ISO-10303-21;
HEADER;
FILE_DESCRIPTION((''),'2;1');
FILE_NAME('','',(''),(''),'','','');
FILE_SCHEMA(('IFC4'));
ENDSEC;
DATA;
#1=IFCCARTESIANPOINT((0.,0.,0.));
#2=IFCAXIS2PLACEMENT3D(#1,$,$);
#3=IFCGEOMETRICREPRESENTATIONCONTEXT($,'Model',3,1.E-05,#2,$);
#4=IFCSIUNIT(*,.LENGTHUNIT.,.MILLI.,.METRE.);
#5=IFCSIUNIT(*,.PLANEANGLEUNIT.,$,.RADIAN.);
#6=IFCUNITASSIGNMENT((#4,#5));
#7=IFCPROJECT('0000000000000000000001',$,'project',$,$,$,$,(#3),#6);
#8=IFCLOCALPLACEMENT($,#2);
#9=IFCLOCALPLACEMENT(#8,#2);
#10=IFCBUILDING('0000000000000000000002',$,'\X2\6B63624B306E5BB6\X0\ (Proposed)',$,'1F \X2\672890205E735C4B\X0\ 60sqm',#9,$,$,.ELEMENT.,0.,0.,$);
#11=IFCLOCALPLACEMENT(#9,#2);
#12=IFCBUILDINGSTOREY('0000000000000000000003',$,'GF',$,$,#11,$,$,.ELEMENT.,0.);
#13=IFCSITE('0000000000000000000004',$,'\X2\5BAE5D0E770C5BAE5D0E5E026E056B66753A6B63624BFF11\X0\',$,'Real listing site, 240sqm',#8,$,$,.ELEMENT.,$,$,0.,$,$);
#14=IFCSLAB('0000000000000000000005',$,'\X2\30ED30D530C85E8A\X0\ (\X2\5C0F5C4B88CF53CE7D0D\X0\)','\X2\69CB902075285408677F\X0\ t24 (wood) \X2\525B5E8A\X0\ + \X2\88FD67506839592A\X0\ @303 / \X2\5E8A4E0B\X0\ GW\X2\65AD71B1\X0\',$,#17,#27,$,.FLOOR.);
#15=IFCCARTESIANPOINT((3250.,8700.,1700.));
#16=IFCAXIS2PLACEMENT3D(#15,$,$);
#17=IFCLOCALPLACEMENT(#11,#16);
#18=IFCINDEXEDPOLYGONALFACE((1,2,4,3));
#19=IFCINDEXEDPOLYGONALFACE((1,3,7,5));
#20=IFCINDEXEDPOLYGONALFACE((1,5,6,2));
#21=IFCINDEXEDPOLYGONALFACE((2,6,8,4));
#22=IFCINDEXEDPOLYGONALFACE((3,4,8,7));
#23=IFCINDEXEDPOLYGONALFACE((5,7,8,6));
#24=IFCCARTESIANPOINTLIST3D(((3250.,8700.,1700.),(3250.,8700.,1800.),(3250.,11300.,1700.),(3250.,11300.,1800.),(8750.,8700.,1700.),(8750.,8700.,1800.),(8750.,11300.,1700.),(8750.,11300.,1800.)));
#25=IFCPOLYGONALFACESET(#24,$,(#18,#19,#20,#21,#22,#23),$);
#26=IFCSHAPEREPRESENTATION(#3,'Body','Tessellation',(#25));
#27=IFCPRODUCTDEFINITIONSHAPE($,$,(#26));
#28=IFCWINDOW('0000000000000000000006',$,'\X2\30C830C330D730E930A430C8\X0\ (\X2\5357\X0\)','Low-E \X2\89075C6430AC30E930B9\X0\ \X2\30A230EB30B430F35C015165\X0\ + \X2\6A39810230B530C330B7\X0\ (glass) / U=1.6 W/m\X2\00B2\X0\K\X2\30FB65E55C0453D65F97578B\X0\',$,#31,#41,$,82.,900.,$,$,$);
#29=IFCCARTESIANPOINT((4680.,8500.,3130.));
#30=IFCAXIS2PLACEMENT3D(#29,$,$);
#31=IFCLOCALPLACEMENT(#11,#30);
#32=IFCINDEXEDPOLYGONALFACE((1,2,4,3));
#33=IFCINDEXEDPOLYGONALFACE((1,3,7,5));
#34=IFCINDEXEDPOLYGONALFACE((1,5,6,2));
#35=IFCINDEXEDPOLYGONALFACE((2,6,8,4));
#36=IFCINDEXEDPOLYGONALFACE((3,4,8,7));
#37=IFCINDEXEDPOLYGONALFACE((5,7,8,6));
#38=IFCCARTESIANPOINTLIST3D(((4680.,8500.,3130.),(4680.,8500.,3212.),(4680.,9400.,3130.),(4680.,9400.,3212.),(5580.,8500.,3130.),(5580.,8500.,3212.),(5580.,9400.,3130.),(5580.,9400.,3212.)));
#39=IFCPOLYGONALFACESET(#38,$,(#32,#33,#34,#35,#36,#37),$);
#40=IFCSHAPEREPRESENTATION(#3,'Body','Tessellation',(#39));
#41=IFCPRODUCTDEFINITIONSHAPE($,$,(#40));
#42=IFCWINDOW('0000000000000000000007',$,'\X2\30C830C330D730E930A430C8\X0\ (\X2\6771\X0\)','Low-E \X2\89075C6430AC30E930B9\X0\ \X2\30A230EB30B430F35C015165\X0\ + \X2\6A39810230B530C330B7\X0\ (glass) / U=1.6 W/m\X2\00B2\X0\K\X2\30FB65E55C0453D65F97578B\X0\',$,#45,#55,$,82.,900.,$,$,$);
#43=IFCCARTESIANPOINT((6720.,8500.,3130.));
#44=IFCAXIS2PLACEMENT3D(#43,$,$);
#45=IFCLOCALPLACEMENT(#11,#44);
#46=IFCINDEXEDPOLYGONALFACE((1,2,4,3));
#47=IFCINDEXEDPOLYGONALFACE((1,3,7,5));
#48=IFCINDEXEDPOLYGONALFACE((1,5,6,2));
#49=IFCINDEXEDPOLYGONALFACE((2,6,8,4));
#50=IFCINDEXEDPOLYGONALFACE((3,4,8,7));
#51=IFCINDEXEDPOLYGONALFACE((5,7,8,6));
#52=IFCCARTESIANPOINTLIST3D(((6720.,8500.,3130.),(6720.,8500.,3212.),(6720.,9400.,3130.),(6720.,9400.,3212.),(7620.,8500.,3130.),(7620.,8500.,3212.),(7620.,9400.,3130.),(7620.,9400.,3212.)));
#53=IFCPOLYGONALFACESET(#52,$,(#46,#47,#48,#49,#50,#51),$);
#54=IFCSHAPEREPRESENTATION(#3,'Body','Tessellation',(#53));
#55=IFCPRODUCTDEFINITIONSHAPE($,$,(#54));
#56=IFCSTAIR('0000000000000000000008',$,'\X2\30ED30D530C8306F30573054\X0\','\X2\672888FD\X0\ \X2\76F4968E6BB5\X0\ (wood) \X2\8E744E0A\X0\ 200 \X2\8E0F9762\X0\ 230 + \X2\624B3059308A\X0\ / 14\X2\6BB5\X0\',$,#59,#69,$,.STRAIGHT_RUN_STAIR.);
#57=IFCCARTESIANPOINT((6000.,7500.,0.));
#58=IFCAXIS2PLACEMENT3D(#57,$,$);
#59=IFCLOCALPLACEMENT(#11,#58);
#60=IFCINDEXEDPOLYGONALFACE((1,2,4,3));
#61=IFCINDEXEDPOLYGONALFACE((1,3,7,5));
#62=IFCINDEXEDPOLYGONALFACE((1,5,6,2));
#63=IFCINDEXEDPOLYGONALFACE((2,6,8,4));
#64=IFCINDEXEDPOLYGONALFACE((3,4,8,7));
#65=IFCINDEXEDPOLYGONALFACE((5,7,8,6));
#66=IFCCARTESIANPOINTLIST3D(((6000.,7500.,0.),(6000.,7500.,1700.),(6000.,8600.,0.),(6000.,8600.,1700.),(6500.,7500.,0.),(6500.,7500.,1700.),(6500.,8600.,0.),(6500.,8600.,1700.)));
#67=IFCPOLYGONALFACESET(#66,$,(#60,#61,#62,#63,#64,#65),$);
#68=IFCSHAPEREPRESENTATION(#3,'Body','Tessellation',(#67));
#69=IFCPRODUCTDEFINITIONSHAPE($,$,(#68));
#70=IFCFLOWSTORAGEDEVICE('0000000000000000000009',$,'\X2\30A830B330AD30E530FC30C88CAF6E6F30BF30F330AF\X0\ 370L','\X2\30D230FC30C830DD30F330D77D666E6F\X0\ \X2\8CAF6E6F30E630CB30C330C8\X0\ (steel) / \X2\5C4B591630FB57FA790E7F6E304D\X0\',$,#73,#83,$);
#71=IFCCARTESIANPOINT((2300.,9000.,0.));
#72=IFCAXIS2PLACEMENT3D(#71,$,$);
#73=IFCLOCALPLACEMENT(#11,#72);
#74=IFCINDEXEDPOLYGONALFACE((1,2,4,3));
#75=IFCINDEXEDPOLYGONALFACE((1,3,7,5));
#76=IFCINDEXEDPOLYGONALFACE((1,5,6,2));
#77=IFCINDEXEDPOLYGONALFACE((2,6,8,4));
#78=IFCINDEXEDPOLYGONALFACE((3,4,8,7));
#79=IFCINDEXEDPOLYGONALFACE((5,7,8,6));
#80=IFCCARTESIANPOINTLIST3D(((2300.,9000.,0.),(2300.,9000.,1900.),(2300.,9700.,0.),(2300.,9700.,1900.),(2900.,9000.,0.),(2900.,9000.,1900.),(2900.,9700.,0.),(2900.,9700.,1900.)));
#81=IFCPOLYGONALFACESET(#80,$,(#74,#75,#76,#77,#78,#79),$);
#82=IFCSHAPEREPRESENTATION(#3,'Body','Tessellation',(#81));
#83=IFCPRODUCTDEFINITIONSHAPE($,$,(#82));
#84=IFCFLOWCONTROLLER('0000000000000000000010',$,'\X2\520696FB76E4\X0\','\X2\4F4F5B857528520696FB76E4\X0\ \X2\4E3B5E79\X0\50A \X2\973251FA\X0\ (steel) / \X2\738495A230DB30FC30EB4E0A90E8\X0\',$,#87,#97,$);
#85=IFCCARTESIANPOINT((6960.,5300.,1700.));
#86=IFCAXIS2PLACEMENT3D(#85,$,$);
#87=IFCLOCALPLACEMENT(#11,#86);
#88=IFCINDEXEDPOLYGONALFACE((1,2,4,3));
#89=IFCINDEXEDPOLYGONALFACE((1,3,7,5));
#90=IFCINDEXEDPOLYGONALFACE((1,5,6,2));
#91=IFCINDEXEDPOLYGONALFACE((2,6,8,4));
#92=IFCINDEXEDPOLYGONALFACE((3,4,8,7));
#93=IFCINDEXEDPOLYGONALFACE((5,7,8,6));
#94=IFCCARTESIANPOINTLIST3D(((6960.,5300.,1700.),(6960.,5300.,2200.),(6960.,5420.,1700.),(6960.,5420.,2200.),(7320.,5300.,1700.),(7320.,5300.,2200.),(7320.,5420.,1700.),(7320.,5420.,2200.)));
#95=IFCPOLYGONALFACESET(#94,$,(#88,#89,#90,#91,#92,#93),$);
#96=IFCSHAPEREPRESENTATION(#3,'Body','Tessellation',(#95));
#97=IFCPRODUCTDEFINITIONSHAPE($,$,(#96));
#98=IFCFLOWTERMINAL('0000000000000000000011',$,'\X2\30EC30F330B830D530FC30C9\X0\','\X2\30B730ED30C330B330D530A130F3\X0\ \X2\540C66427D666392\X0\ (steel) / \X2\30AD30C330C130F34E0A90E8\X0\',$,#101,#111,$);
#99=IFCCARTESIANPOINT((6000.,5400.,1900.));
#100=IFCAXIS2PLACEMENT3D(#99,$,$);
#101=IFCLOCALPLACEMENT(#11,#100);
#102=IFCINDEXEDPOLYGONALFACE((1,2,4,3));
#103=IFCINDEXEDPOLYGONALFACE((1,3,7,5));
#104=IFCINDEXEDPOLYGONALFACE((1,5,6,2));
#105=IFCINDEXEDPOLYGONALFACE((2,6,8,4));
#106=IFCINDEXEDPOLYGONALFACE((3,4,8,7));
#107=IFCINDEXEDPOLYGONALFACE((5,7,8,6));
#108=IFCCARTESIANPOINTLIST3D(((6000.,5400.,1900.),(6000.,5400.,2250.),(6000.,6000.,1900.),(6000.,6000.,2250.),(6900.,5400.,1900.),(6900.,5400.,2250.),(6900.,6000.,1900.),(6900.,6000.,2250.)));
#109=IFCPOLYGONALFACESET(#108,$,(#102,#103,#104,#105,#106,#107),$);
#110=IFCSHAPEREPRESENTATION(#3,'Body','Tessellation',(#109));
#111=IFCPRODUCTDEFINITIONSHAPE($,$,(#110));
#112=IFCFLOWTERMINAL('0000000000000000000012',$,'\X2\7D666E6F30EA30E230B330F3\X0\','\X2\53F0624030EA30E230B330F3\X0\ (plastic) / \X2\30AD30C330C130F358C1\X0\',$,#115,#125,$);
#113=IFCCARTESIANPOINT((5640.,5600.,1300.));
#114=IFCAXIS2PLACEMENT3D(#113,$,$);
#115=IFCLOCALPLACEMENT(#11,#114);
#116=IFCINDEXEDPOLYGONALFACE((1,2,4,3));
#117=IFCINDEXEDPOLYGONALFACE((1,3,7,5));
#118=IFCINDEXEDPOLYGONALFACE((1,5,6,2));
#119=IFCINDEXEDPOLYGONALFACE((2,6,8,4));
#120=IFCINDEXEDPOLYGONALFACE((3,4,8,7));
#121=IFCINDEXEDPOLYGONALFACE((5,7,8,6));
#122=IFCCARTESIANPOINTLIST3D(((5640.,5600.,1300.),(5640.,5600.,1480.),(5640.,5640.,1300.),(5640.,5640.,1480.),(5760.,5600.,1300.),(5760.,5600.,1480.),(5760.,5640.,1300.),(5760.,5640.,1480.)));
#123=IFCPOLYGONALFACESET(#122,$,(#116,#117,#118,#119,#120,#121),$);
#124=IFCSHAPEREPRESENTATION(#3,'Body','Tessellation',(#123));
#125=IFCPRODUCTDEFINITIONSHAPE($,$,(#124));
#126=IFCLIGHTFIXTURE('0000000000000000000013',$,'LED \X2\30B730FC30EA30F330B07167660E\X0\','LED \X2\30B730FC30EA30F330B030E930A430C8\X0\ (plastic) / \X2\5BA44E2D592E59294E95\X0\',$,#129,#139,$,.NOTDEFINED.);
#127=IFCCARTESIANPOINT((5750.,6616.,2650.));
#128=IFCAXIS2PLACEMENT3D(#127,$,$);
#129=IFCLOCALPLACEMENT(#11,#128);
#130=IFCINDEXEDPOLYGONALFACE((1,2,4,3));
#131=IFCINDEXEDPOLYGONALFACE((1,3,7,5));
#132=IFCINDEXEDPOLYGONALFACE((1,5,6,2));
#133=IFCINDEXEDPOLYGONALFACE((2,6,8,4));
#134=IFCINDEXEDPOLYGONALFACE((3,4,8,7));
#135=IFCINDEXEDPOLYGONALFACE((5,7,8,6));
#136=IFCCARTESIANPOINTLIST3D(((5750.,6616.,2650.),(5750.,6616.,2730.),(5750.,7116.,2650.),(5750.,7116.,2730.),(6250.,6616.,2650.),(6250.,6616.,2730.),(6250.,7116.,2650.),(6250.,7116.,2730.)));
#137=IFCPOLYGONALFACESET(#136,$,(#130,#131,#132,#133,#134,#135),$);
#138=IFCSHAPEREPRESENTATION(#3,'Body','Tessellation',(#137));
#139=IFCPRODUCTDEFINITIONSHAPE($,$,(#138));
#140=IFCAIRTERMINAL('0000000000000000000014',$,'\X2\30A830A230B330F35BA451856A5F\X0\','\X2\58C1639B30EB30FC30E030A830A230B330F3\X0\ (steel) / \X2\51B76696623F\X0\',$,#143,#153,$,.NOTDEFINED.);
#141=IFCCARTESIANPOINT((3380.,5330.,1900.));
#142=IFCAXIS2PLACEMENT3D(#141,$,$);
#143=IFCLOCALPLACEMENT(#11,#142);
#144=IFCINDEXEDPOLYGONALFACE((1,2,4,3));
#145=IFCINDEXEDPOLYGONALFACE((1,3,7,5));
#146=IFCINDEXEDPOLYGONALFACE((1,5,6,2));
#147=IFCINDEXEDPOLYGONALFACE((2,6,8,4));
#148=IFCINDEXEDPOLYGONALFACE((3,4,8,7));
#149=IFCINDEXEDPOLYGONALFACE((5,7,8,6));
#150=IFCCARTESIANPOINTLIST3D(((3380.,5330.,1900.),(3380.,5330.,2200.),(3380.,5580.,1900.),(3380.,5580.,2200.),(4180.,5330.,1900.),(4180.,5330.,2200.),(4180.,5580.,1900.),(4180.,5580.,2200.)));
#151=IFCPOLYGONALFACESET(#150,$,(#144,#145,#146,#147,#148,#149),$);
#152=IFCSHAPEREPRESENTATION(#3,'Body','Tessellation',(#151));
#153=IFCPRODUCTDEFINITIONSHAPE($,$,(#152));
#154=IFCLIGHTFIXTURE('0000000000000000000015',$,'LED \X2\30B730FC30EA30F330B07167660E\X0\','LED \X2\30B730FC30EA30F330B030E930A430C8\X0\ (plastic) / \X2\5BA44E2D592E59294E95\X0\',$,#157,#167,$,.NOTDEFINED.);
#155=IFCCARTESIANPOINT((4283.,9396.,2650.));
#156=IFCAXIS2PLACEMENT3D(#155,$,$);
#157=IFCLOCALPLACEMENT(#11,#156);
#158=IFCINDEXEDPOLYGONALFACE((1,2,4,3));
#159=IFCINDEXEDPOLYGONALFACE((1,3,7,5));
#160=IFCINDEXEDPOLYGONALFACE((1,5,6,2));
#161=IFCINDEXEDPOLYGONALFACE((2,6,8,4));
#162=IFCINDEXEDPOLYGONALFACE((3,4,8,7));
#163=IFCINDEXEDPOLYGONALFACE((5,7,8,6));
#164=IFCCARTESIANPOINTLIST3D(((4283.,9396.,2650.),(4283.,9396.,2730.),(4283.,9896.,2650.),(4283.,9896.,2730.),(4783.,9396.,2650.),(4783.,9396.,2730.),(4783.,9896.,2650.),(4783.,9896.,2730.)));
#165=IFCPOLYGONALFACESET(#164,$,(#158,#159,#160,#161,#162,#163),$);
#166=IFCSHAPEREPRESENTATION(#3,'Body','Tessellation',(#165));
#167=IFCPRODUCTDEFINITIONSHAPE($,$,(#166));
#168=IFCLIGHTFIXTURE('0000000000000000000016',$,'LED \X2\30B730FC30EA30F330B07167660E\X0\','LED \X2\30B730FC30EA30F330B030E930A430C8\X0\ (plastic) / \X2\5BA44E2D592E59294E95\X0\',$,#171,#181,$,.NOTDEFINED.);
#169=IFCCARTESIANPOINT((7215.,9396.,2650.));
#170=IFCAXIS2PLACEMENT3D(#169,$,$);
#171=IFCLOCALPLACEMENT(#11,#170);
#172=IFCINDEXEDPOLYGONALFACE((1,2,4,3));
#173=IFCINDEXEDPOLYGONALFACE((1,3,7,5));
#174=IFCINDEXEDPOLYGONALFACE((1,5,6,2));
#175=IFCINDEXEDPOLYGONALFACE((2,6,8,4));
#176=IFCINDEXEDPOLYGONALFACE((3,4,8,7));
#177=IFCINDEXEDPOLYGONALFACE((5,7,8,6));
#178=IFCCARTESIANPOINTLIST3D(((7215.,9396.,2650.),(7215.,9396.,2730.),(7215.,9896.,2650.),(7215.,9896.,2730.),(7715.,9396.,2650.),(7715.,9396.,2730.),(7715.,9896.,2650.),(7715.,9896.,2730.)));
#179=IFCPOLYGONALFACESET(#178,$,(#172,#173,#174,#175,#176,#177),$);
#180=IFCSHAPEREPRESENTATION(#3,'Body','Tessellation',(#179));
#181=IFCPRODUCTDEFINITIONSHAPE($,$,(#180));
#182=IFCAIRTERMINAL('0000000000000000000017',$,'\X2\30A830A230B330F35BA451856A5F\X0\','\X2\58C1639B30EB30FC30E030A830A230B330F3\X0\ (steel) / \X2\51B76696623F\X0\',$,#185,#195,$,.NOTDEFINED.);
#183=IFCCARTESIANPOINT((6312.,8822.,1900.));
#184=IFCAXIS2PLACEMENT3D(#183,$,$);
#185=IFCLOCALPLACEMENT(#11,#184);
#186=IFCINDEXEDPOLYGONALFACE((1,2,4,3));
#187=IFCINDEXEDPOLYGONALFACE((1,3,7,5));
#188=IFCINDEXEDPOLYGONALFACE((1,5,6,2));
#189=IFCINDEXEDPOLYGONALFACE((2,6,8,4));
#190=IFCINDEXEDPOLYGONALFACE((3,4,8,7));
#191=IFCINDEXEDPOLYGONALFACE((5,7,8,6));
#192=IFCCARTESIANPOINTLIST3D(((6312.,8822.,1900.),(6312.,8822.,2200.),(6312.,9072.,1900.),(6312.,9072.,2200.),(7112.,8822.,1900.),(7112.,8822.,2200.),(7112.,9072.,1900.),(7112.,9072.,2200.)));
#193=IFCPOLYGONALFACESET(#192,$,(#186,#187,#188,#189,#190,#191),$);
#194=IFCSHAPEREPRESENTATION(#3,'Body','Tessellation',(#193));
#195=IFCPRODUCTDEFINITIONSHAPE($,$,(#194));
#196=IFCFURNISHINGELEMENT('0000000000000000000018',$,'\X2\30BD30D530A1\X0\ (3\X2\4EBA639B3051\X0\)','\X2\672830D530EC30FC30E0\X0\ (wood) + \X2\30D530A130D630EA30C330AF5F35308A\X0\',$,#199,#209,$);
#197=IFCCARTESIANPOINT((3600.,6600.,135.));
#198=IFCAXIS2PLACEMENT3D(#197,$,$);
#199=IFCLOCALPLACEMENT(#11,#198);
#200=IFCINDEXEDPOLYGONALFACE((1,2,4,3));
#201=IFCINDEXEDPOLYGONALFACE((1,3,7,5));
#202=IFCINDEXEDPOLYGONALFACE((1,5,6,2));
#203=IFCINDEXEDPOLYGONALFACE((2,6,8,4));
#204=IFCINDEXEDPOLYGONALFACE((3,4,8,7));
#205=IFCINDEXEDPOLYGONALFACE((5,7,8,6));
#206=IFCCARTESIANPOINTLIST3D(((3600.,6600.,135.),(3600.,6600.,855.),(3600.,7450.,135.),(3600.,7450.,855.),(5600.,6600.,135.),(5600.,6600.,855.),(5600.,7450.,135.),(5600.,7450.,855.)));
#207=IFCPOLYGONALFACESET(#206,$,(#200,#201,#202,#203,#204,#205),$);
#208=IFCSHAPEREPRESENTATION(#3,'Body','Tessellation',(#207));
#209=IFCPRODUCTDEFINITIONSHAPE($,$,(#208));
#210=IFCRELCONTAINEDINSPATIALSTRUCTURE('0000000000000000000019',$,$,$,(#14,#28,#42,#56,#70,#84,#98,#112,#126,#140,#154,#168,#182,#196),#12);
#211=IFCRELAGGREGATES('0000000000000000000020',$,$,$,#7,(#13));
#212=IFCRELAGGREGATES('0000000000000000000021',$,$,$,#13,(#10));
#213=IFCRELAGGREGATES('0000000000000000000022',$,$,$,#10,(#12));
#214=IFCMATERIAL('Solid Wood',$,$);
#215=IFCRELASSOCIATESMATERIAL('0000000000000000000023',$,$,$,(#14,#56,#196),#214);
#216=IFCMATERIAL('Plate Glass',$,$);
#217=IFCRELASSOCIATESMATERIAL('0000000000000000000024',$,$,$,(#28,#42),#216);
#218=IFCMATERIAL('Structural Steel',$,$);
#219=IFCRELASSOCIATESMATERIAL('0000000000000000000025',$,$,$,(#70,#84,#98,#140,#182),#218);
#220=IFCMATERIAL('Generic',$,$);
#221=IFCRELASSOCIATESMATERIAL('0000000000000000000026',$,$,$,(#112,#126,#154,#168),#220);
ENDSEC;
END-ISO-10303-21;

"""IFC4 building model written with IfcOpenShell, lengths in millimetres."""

from ifc_helpers import new_model, si_unit, frame, frame_2d, origin, place, context, project, spatial, rectangle, extrude, material, element, save


model = new_model("IFC4")

# Units and contexts
model_context = context("Model", 3, precision=1e-05, world=origin())
ifc_project = project(units=[si_unit("LENGTHUNIT", "METRE", prefix="MILLI"), si_unit("PLANEANGLEUNIT", "RADIAN")], contexts=[model_context])

# Site, building, storey
site_placement = place(None, origin())
site = spatial("IfcSite", under=ifc_project, at=site_placement, Name="宮崎県宮崎市清武町正手１", ObjectType="Real listing site, 240sqm", CompositionType="ELEMENT", RefElevation=0.0)
building_placement = place(site_placement, origin())
building = spatial("IfcBuilding", under=site, at=building_placement, Name="正手の家 (Proposed)", ObjectType="1F 木造平屋 60sqm", CompositionType="ELEMENT", ElevationOfRefHeight=0.0, ElevationOfTerrain=0.0)
storey_placement = place(building_placement, origin())
storey = spatial("IfcBuildingStorey", under=building, at=storey_placement, Name="GF", CompositionType="ELEMENT", Elevation=0.0)

# Shared definitions
ifc_material_1 = material(Name="Solid Wood")

# Slab
slab_placement = place(storey_placement, frame((3250.0, 8700.0, 1700.0)))
element("IfcSlab", 1, at=slab_placement, inside=storey, material=ifc_material_1, Name="ロフト床 (小屋裏収納)", Description="構造用合板 t24 (wood) 剛床 + 製材根太 @303 / 床下 GW断熱", PredefinedType="FLOOR", context=model_context, shape_type="SweptSolid", body=[
    extrude(rectangle(XDim=5500.0, YDim=2600.0, at=frame_2d((2750.0, 1300.0))), frame((3250.0, 8700.0, 1700.0)), (0.0, 0.0, 1.0), 100.0),
])

# Windows
ifc_material_2 = material(Name="Plate Glass")
window_1_placement = place(storey_placement, frame((4680.0, 8500.0, 3130.0)))
element("IfcWindow", 2, at=window_1_placement, inside=storey, material=ifc_material_2, Name="トップライト (南)", Description="Low-E 複層ガラス アルゴン封入 + 樹脂サッシ (glass) / U=1.6 W/m²K・日射取得型", OverallHeight=82.0, OverallWidth=900.0, context=model_context, shape_type="SweptSolid", body=[
    extrude(rectangle(XDim=900.0, YDim=900.0, at=frame_2d((450.0, 450.0))), frame((4680.0, 8500.0, 3130.0)), (0.0, 0.0, 1.0), 82.0),
])
window_2_placement = place(storey_placement, frame((6720.0, 8500.0, 3130.0)))
element("IfcWindow", 3, at=window_2_placement, inside=storey, material=ifc_material_2, Name="トップライト (東)", Description="Low-E 複層ガラス アルゴン封入 + 樹脂サッシ (glass) / U=1.6 W/m²K・日射取得型", OverallHeight=82.0, OverallWidth=900.0, context=model_context, shape_type="SweptSolid", body=[
    extrude(rectangle(XDim=900.0, YDim=900.0, at=frame_2d((450.0, 450.0))), frame((6720.0, 8500.0, 3130.0)), (0.0, 0.0, 1.0), 82.0),
])

# Stair
stair_placement = place(storey_placement, frame((6000.0, 7500.0, 0.0)))
element("IfcStair", 4, at=stair_placement, inside=storey, material=ifc_material_1, Name="ロフトはしご", Description="木製 直階段 (wood) 蹴上 200 踏面 230 + 手すり / 14段", PredefinedType="STRAIGHT_RUN_STAIR", context=model_context, shape_type="SweptSolid", body=[
    extrude(rectangle(XDim=500.0, YDim=1100.0, at=frame_2d((250.0, 550.0))), frame((6000.0, 7500.0, 0.0)), (0.0, 0.0, 1.0), 1700.0),
])

# Flow storage device
ifc_material_3 = material(Name="Structural Steel")
flow_storage_device_placement = place(storey_placement, frame((2300.0, 9000.0, 0.0)))
element("IfcFlowStorageDevice", 5, at=flow_storage_device_placement, inside=storey, material=ifc_material_3, Name="エコキュート貯湯タンク 370L", Description="ヒートポンプ給湯 貯湯ユニット (steel) / 屋外・基礎置き", context=model_context, shape_type="SweptSolid", body=[
    extrude(rectangle(XDim=600.0, YDim=700.0, at=frame_2d((300.0, 350.0))), frame((2300.0, 9000.0, 0.0)), (0.0, 0.0, 1.0), 1900.0),
])

# Flow controller
flow_controller_placement = place(storey_placement, frame((6960.0, 5300.0, 1700.0)))
element("IfcFlowController", 6, at=flow_controller_placement, inside=storey, material=ifc_material_3, Name="分電盤", Description="住宅用分電盤 主幹50A 露出 (steel) / 玄関ホール上部", context=model_context, shape_type="SweptSolid", body=[
    extrude(rectangle(XDim=360.0, YDim=120.0, at=frame_2d((180.0, 60.0))), frame((6960.0, 5300.0, 1700.0)), (0.0, 0.0, 1.0), 500.0),
])

# Flow terminals
flow_terminal_1_placement = place(storey_placement, frame((6000.0, 5400.0, 1900.0)))
element("IfcFlowTerminal", 7, at=flow_terminal_1_placement, inside=storey, material=ifc_material_3, Name="レンジフード", Description="シロッコファン 同時給排 (steel) / キッチン上部", context=model_context, shape_type="SweptSolid", body=[
    extrude(rectangle(XDim=900.0, YDim=600.0, at=frame_2d((450.0, 300.0))), frame((6000.0, 5400.0, 1900.0)), (0.0, 0.0, 1.0), 350.0),
])
ifc_material_4 = material(Name="Generic")
flow_terminal_2_placement = place(storey_placement, frame((5640.0, 5600.0, 1300.0)))
element("IfcFlowTerminal", 8, at=flow_terminal_2_placement, inside=storey, material=ifc_material_4, Name="給湯リモコン", Description="台所リモコン (plastic) / キッチン壁", context=model_context, shape_type="SweptSolid", body=[
    extrude(rectangle(XDim=120.0, YDim=40.0, at=frame_2d((60.0, 20.0))), frame((5640.0, 5600.0, 1300.0)), (0.0, 0.0, 1.0), 180.0),
])

# Light fixture
light_fixture_1_placement = place(storey_placement, frame((5750.0, 6616.0, 2650.0)))
element("IfcLightFixture", 9, at=light_fixture_1_placement, inside=storey, material=ifc_material_4, Name="LED シーリング照明", Description="LED シーリングライト (plastic) / 室中央天井", PredefinedType="NOTDEFINED", context=model_context, shape_type="SweptSolid", body=[
    extrude(rectangle(XDim=500.0, YDim=500.0, at=frame_2d((250.0, 250.0))), frame((5750.0, 6616.0, 2650.0)), (0.0, 0.0, 1.0), 80.0),
])

# Air terminal
air_terminal_1_placement = place(storey_placement, frame((3380.0, 5330.0, 1900.0)))
element("IfcAirTerminal", 10, at=air_terminal_1_placement, inside=storey, material=ifc_material_3, Name="エアコン室内機", Description="壁掛ルームエアコン (steel) / 冷暖房", PredefinedType="NOTDEFINED", context=model_context, shape_type="SweptSolid", body=[
    extrude(rectangle(XDim=800.0, YDim=250.0, at=frame_2d((400.0, 125.0))), frame((3380.0, 5330.0, 1900.0)), (0.0, 0.0, 1.0), 300.0),
])

# Light fixtures
light_fixture_2_placement = place(storey_placement, frame((4283.0, 9396.0, 2650.0)))
element("IfcLightFixture", 11, at=light_fixture_2_placement, inside=storey, material=ifc_material_4, Name="LED シーリング照明", Description="LED シーリングライト (plastic) / 室中央天井", PredefinedType="NOTDEFINED", context=model_context, shape_type="SweptSolid", body=[
    extrude(rectangle(XDim=500.0, YDim=500.0, at=frame_2d((250.0, 250.0))), frame((4283.0, 9396.0, 2650.0)), (0.0, 0.0, 1.0), 80.0),
])
light_fixture_3_placement = place(storey_placement, frame((7215.0, 9396.0, 2650.0)))
element("IfcLightFixture", 12, at=light_fixture_3_placement, inside=storey, material=ifc_material_4, Name="LED シーリング照明", Description="LED シーリングライト (plastic) / 室中央天井", PredefinedType="NOTDEFINED", context=model_context, shape_type="SweptSolid", body=[
    extrude(rectangle(XDim=500.0, YDim=500.0, at=frame_2d((250.0, 250.0))), frame((7215.0, 9396.0, 2650.0)), (0.0, 0.0, 1.0), 80.0),
])

# Air terminal
air_terminal_2_placement = place(storey_placement, frame((6312.0, 8822.0, 1900.0)))
element("IfcAirTerminal", 13, at=air_terminal_2_placement, inside=storey, material=ifc_material_3, Name="エアコン室内機", Description="壁掛ルームエアコン (steel) / 冷暖房", PredefinedType="NOTDEFINED", context=model_context, shape_type="SweptSolid", body=[
    extrude(rectangle(XDim=800.0, YDim=250.0, at=frame_2d((400.0, 125.0))), frame((6312.0, 8822.0, 1900.0)), (0.0, 0.0, 1.0), 300.0),
])

# Furnishing element
furnishing_1_placement = place(storey_placement, frame((3600.0, 6600.0, 135.0)))
element("IfcFurnishingElement", 14, at=furnishing_1_placement, inside=storey, material=ifc_material_1, Name="ソファ (3人掛け)", Description="木フレーム (wood) + ファブリック張り", context=model_context, shape_type="SweptSolid", body=[
    extrude(rectangle(XDim=2000.0, YDim=850.0, at=frame_2d((1000.0, 425.0))), frame((3600.0, 6600.0, 135.0)), (0.0, 0.0, 1.0), 720.0),
])

save(model, "model.ifc")
